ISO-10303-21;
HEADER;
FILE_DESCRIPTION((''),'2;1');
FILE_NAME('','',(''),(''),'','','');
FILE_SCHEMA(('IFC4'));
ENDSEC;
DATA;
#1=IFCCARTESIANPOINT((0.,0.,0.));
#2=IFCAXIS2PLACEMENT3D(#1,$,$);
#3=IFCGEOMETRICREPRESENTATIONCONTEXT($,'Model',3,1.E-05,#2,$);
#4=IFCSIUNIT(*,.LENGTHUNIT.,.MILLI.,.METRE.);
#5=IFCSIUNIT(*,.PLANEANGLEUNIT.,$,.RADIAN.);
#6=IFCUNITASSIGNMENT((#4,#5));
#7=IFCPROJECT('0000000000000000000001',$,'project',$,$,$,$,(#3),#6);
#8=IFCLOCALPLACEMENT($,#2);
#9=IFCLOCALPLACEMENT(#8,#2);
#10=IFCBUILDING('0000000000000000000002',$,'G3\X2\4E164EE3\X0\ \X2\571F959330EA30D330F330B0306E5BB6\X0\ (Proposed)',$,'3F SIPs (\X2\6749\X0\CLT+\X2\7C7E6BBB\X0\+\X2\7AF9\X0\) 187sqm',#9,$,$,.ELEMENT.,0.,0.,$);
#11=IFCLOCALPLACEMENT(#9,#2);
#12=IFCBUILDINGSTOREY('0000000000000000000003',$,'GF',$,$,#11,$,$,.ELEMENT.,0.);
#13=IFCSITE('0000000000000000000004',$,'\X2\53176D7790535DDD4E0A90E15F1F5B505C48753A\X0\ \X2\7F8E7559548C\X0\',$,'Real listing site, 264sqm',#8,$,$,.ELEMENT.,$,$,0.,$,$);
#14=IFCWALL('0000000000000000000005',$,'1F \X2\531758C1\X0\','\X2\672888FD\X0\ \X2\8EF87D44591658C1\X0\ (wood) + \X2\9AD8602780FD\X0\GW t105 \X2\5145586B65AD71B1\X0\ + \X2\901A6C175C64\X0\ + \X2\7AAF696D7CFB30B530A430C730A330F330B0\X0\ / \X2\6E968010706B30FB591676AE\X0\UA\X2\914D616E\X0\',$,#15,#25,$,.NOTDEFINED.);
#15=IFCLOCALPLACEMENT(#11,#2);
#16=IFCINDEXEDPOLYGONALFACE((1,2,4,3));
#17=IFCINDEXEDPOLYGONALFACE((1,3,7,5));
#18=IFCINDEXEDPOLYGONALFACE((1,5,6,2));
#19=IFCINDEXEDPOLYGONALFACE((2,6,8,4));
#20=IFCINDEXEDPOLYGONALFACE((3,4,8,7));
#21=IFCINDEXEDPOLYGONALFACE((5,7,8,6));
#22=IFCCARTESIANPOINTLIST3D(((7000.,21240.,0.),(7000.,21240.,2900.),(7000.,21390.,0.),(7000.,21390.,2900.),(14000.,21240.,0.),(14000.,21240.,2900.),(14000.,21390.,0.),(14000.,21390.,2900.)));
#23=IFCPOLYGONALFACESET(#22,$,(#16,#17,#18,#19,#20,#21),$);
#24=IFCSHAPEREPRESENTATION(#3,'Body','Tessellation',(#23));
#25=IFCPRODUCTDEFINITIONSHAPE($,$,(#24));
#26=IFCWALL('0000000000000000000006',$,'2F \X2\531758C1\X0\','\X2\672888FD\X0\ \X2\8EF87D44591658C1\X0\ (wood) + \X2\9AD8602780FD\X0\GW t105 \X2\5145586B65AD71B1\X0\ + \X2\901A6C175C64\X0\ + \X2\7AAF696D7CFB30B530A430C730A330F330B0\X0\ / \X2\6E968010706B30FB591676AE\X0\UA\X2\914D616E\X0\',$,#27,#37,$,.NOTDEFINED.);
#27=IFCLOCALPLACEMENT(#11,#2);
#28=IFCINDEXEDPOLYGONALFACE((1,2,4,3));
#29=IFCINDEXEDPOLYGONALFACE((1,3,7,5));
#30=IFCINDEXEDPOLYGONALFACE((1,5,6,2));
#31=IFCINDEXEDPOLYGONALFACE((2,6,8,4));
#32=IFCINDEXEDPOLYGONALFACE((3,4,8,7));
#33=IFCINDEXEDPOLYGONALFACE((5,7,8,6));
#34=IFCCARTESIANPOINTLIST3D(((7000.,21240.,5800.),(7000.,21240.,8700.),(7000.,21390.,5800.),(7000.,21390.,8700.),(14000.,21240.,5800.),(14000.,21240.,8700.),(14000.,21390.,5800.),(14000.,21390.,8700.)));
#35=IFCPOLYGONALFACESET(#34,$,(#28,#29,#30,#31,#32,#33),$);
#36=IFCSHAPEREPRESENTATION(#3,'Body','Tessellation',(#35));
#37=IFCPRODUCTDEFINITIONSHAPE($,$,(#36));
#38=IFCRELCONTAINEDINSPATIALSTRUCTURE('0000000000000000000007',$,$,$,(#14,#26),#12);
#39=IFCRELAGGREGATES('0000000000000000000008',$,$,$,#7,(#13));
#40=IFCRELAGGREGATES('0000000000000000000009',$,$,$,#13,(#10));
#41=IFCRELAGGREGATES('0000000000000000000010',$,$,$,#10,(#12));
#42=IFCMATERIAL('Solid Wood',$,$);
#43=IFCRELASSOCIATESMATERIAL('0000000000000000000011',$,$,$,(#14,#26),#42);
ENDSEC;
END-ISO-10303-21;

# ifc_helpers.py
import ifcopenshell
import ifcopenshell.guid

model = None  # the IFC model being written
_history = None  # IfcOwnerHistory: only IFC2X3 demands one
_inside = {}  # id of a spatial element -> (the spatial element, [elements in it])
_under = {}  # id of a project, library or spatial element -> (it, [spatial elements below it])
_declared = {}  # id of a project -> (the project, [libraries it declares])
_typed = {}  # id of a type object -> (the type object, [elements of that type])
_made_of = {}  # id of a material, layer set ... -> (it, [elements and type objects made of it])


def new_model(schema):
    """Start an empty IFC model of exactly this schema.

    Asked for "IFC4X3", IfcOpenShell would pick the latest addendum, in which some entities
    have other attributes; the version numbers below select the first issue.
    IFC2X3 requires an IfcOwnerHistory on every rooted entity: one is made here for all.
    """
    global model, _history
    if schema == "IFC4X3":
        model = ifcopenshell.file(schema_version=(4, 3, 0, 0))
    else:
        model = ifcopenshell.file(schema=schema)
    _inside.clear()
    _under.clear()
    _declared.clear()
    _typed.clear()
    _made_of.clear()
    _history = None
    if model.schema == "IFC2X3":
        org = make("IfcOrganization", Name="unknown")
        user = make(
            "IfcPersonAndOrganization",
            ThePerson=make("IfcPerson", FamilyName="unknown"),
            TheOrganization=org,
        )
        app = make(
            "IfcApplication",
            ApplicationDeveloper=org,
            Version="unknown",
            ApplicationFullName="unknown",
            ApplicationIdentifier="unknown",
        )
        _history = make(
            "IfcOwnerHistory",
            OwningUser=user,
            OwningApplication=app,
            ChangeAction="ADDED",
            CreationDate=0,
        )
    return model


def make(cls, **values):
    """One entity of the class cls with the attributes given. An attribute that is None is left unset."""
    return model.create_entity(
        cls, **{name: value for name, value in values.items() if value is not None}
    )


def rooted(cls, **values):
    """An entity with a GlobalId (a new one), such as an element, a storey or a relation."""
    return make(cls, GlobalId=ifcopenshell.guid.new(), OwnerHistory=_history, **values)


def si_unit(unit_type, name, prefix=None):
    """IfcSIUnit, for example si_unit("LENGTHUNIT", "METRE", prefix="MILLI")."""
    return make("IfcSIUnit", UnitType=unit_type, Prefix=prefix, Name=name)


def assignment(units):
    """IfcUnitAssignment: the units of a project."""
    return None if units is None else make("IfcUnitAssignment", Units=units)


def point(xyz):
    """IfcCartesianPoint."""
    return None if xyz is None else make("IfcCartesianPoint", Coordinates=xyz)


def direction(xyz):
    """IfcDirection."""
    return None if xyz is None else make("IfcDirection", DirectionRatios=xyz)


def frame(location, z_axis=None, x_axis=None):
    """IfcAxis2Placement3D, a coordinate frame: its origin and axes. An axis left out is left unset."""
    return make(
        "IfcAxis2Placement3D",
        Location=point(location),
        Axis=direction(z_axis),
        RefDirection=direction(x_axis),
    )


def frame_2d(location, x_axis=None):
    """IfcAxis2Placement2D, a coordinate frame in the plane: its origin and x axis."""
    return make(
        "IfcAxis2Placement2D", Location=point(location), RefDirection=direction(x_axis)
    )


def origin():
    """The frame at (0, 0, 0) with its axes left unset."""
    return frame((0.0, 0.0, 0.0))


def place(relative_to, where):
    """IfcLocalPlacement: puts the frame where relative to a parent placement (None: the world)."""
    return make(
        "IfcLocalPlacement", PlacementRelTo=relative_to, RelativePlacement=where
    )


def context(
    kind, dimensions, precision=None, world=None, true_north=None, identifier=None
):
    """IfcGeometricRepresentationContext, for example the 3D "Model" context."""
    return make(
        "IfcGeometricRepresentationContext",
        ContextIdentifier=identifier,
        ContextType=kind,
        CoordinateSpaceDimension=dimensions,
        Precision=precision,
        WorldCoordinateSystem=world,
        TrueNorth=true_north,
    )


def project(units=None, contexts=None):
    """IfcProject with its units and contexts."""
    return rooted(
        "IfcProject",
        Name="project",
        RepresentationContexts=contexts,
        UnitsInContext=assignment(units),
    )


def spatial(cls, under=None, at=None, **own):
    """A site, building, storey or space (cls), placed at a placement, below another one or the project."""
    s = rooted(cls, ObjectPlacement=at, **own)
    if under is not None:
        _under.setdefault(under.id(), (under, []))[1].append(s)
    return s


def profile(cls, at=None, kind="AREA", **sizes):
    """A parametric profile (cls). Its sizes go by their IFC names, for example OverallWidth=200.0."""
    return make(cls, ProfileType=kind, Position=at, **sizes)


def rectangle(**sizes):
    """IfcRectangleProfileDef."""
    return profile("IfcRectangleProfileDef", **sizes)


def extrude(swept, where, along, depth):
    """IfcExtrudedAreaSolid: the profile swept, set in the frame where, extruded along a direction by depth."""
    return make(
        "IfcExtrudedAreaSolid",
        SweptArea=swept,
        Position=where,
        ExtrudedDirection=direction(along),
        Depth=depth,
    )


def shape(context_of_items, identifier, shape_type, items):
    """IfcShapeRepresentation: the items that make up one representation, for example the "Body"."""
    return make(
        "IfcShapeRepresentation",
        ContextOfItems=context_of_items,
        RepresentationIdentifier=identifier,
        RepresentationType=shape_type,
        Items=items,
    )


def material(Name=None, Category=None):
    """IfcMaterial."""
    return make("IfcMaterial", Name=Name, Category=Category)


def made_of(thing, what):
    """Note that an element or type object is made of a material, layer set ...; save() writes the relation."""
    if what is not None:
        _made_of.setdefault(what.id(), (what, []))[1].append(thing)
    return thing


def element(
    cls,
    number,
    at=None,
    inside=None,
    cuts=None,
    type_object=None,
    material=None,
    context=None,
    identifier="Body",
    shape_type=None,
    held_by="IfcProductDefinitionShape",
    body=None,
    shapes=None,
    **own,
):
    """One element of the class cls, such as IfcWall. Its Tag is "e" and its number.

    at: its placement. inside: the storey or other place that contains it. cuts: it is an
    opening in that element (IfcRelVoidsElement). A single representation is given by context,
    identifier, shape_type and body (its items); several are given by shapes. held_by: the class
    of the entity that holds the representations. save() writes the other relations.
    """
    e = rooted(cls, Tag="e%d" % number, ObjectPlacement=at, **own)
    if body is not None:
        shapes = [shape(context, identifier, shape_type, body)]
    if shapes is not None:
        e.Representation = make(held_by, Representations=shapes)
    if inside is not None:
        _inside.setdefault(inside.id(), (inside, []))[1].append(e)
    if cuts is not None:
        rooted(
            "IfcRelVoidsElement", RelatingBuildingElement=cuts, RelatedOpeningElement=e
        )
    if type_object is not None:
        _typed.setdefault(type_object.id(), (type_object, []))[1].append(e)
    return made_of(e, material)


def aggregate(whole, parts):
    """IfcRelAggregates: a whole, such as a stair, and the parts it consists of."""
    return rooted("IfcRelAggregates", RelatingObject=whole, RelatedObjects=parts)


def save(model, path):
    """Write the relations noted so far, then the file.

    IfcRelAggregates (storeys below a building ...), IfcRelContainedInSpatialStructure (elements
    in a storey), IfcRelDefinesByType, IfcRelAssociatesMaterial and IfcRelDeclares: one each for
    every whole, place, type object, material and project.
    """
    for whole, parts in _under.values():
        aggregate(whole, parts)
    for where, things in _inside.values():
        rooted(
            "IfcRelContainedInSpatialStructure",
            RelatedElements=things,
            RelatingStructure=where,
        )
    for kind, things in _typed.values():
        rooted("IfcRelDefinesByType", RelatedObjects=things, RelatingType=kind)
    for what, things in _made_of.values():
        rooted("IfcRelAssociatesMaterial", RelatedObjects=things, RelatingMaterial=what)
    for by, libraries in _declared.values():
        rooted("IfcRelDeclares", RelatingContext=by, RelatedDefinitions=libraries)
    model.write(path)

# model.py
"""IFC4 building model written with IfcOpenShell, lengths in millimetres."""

from ifc_helpers import new_model, si_unit, frame, frame_2d, origin, place, context, project, spatial, rectangle, extrude, material, element, save


model = new_model("IFC4")

# Units and contexts
model_context = context("Model", 3, precision=1e-05, world=origin())
ifc_project = project(units=[si_unit("LENGTHUNIT", "METRE", prefix="MILLI"), si_unit("PLANEANGLEUNIT", "RADIAN")], contexts=[model_context])

# Site, building, storey
site_placement = place(None, origin())
site = spatial("IfcSite", under=ifc_project, at=site_placement, Name="北海道川上郡弟子屈町 美留和", ObjectType="Real listing site, 264sqm", CompositionType="ELEMENT", RefElevation=0.0)
building_placement = place(site_placement, origin())
building = spatial("IfcBuilding", under=site, at=building_placement, Name="G3世代 土間リビングの家 (Proposed)", ObjectType="3F SIPs (杉CLT+籾殻+竹) 187sqm", CompositionType="ELEMENT", ElevationOfRefHeight=0.0, ElevationOfTerrain=0.0)
storey_placement = place(building_placement, origin())
storey = spatial("IfcBuildingStorey", under=building, at=storey_placement, Name="GF", CompositionType="ELEMENT", Elevation=0.0)

# Shared definitions
ifc_material_1 = material(Name="Solid Wood")

# Wall
wall_1_placement = place(storey_placement, frame((3500.0, 10620.0, 0.0)))
element("IfcWall", 1, at=wall_1_placement, inside=storey, material=ifc_material_1, Name="1F 北壁", Description="木製 軸組外壁 (wood) + 高性能GW t105 充填断熱 + 通気層 + 窯業系サイディング / 準耐火・外皮UA配慮", PredefinedType="NOTDEFINED", context=model_context, shape_type="SweptSolid", body=[
    extrude(rectangle(XDim=7000.0, YDim=150.0, at=frame_2d((3500.0, 75.0))), frame((3500.0, 10620.0, 0.0)), (0.0, 0.0, 1.0), 2900.0),
])

# Wall
wall_2_placement = place(storey_placement, frame((3500.0, 10620.0, 2900.0)))
element("IfcWall", 2, at=wall_2_placement, inside=storey, material=ifc_material_1, Name="2F 北壁", Description="木製 軸組外壁 (wood) + 高性能GW t105 充填断熱 + 通気層 + 窯業系サイディング / 準耐火・外皮UA配慮", PredefinedType="NOTDEFINED", context=model_context, shape_type="SweptSolid", body=[
    extrude(rectangle(XDim=7000.0, YDim=150.0, at=frame_2d((3500.0, 75.0))), frame((3500.0, 10620.0, 2900.0)), (0.0, 0.0, 1.0), 2900.0),
])

save(model, "model.ifc")
